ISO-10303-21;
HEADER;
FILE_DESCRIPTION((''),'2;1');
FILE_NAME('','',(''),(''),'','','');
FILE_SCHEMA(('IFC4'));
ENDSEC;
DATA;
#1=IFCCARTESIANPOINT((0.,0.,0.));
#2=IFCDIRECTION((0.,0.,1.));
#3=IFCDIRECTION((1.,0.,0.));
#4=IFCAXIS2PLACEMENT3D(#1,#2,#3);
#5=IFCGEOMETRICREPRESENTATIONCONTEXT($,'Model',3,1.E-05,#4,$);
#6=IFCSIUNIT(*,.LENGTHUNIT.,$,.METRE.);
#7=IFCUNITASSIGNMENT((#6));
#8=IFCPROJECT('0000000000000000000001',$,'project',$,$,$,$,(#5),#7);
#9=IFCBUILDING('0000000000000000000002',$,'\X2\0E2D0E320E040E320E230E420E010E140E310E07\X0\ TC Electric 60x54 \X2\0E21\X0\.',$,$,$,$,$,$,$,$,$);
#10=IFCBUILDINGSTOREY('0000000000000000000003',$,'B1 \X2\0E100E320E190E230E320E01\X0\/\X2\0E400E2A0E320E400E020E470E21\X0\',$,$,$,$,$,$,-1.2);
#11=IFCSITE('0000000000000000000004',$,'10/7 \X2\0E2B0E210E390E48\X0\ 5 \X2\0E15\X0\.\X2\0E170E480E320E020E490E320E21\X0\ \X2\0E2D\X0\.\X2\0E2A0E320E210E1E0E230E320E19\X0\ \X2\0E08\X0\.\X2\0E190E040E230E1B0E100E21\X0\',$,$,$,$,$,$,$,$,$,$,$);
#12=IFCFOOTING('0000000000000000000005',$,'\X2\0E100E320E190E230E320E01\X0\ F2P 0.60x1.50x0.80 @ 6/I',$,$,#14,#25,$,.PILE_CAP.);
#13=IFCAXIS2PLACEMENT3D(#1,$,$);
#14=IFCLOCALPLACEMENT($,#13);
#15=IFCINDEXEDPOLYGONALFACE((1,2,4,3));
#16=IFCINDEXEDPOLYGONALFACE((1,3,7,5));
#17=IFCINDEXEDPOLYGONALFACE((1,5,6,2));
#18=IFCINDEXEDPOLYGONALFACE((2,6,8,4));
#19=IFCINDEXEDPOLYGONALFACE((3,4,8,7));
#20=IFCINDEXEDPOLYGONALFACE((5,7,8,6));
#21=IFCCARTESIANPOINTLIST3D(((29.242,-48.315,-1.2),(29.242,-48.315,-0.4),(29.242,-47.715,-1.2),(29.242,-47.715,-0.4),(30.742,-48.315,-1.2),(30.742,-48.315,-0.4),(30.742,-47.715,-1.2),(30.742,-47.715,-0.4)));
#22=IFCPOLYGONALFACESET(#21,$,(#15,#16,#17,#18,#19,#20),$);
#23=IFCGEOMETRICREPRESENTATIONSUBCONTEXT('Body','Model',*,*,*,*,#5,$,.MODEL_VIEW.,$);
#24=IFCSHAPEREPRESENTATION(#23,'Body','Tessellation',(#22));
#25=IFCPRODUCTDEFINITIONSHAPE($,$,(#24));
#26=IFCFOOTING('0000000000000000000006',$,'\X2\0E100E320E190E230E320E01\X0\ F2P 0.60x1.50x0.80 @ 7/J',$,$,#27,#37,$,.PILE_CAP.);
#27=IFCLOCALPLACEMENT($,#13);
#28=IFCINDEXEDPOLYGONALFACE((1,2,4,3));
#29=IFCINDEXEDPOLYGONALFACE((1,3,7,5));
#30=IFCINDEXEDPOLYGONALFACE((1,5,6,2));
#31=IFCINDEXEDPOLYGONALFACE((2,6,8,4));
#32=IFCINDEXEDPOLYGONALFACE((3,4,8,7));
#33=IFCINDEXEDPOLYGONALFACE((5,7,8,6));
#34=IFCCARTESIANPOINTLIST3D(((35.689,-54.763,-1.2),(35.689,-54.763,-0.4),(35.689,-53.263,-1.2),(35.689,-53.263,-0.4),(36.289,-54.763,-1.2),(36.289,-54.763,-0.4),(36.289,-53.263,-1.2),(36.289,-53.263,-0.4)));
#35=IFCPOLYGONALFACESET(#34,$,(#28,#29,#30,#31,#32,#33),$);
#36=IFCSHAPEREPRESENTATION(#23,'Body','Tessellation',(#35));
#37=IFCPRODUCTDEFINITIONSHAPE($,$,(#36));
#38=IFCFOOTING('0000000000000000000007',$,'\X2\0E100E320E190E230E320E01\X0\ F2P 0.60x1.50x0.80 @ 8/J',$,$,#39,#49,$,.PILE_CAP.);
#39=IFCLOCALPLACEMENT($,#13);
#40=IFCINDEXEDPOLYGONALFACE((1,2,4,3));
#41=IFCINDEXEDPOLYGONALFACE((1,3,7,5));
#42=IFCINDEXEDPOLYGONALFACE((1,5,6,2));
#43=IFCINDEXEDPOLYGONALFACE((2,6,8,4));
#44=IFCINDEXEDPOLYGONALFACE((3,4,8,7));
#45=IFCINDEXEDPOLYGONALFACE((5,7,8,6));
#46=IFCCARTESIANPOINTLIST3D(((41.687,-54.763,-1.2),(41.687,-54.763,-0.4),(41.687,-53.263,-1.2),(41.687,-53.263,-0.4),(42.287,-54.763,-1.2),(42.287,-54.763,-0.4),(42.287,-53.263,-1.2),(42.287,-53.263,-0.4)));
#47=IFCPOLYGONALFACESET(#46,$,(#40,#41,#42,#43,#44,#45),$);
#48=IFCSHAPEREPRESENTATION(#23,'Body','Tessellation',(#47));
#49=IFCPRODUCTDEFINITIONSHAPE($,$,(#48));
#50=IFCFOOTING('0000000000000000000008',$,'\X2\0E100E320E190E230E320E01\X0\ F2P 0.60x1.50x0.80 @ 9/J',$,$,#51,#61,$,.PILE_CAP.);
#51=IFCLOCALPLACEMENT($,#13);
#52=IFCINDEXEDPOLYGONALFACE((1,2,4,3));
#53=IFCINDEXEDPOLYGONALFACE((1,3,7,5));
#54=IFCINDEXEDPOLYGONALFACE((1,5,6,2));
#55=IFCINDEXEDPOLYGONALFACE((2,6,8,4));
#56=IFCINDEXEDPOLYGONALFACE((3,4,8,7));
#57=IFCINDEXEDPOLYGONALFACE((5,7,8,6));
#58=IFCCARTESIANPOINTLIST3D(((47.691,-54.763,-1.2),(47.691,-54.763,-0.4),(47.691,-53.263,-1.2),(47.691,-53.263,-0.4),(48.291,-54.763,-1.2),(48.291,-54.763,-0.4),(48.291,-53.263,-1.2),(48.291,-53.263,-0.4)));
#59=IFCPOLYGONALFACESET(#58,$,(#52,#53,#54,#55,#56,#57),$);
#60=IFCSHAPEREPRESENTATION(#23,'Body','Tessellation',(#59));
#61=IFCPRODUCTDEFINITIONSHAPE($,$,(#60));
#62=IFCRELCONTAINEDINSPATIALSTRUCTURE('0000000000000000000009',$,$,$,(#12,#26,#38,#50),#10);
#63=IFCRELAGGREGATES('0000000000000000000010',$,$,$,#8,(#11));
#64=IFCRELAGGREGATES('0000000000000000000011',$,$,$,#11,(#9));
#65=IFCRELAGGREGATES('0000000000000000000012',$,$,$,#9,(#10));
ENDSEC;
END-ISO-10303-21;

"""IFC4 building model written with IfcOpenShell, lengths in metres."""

from ifc_helpers import new_model, si_unit, frame, origin, origin_with_axes, origin_2d, place, context, subcontext, project, spatial, rectangle, extrude, element, save


model = new_model("IFC4")

# Units and contexts
model_context = context("Model", 3, precision=1e-05, world=origin_with_axes())
body_context = subcontext(model_context, "Body", "Model", "MODEL_VIEW")
ifc_project = project(units=[si_unit("LENGTHUNIT", "METRE")], contexts=[model_context])

# Site, building, storey
site = spatial("IfcSite", under=ifc_project, Name="10/7 หมู่ 5 ต.ท่าข้าม อ.สามพราน จ.นครปฐม")
building = spatial("IfcBuilding", under=site, Name="อาคารโกดัง TC Electric 60x54 ม.")
storey = spatial("IfcBuildingStorey", under=building, Name="B1 ฐานราก/เสาเข็ม", Elevation=-1.2)

# Footings
for number, where, z_axis, x_axis, name in (
    (1, (29.992, -48.015, -1.2), (0.0, 0.0, 1.0), (1.0, 0.0, 0.0), "ฐานราก F2P 0.60x1.50x0.80 @ 6/I"),
):
    element("IfcFooting", number, at=place(None, frame(where, z_axis=z_axis, x_axis=x_axis)), inside=storey, Name=name, PredefinedType="PILE_CAP", context=body_context, shape_type="SweptSolid", body=[
        extrude(rectangle(XDim=1.5, YDim=0.6, at=origin_2d()), origin(), (0.0, 0.0, 1.0), 0.8),
    ])
for number, where, z_axis, x_axis, name in (
    (2, (35.989, -54.013, -1.2), (0.0, 0.0, 1.0), (1.0, 0.0, 0.0), "ฐานราก F2P 0.60x1.50x0.80 @ 7/J"),
    (3, (41.987, -54.013, -1.2), (0.0, 0.0, 1.0), (1.0, 0.0, 0.0), "ฐานราก F2P 0.60x1.50x0.80 @ 8/J"),
    (4, (47.991, -54.013, -1.2), (0.0, 0.0, 1.0), (1.0, 0.0, 0.0), "ฐานราก F2P 0.60x1.50x0.80 @ 9/J"),
):
    element("IfcFooting", number, at=place(None, frame(where, z_axis=z_axis, x_axis=x_axis)), inside=storey, Name=name, PredefinedType="PILE_CAP", context=body_context, shape_type="SweptSolid", body=[
        extrude(rectangle(XDim=0.6, YDim=1.5, at=origin_2d()), origin(), (0.0, 0.0, 1.0), 0.8),
    ])

save(model, "model.ifc")
